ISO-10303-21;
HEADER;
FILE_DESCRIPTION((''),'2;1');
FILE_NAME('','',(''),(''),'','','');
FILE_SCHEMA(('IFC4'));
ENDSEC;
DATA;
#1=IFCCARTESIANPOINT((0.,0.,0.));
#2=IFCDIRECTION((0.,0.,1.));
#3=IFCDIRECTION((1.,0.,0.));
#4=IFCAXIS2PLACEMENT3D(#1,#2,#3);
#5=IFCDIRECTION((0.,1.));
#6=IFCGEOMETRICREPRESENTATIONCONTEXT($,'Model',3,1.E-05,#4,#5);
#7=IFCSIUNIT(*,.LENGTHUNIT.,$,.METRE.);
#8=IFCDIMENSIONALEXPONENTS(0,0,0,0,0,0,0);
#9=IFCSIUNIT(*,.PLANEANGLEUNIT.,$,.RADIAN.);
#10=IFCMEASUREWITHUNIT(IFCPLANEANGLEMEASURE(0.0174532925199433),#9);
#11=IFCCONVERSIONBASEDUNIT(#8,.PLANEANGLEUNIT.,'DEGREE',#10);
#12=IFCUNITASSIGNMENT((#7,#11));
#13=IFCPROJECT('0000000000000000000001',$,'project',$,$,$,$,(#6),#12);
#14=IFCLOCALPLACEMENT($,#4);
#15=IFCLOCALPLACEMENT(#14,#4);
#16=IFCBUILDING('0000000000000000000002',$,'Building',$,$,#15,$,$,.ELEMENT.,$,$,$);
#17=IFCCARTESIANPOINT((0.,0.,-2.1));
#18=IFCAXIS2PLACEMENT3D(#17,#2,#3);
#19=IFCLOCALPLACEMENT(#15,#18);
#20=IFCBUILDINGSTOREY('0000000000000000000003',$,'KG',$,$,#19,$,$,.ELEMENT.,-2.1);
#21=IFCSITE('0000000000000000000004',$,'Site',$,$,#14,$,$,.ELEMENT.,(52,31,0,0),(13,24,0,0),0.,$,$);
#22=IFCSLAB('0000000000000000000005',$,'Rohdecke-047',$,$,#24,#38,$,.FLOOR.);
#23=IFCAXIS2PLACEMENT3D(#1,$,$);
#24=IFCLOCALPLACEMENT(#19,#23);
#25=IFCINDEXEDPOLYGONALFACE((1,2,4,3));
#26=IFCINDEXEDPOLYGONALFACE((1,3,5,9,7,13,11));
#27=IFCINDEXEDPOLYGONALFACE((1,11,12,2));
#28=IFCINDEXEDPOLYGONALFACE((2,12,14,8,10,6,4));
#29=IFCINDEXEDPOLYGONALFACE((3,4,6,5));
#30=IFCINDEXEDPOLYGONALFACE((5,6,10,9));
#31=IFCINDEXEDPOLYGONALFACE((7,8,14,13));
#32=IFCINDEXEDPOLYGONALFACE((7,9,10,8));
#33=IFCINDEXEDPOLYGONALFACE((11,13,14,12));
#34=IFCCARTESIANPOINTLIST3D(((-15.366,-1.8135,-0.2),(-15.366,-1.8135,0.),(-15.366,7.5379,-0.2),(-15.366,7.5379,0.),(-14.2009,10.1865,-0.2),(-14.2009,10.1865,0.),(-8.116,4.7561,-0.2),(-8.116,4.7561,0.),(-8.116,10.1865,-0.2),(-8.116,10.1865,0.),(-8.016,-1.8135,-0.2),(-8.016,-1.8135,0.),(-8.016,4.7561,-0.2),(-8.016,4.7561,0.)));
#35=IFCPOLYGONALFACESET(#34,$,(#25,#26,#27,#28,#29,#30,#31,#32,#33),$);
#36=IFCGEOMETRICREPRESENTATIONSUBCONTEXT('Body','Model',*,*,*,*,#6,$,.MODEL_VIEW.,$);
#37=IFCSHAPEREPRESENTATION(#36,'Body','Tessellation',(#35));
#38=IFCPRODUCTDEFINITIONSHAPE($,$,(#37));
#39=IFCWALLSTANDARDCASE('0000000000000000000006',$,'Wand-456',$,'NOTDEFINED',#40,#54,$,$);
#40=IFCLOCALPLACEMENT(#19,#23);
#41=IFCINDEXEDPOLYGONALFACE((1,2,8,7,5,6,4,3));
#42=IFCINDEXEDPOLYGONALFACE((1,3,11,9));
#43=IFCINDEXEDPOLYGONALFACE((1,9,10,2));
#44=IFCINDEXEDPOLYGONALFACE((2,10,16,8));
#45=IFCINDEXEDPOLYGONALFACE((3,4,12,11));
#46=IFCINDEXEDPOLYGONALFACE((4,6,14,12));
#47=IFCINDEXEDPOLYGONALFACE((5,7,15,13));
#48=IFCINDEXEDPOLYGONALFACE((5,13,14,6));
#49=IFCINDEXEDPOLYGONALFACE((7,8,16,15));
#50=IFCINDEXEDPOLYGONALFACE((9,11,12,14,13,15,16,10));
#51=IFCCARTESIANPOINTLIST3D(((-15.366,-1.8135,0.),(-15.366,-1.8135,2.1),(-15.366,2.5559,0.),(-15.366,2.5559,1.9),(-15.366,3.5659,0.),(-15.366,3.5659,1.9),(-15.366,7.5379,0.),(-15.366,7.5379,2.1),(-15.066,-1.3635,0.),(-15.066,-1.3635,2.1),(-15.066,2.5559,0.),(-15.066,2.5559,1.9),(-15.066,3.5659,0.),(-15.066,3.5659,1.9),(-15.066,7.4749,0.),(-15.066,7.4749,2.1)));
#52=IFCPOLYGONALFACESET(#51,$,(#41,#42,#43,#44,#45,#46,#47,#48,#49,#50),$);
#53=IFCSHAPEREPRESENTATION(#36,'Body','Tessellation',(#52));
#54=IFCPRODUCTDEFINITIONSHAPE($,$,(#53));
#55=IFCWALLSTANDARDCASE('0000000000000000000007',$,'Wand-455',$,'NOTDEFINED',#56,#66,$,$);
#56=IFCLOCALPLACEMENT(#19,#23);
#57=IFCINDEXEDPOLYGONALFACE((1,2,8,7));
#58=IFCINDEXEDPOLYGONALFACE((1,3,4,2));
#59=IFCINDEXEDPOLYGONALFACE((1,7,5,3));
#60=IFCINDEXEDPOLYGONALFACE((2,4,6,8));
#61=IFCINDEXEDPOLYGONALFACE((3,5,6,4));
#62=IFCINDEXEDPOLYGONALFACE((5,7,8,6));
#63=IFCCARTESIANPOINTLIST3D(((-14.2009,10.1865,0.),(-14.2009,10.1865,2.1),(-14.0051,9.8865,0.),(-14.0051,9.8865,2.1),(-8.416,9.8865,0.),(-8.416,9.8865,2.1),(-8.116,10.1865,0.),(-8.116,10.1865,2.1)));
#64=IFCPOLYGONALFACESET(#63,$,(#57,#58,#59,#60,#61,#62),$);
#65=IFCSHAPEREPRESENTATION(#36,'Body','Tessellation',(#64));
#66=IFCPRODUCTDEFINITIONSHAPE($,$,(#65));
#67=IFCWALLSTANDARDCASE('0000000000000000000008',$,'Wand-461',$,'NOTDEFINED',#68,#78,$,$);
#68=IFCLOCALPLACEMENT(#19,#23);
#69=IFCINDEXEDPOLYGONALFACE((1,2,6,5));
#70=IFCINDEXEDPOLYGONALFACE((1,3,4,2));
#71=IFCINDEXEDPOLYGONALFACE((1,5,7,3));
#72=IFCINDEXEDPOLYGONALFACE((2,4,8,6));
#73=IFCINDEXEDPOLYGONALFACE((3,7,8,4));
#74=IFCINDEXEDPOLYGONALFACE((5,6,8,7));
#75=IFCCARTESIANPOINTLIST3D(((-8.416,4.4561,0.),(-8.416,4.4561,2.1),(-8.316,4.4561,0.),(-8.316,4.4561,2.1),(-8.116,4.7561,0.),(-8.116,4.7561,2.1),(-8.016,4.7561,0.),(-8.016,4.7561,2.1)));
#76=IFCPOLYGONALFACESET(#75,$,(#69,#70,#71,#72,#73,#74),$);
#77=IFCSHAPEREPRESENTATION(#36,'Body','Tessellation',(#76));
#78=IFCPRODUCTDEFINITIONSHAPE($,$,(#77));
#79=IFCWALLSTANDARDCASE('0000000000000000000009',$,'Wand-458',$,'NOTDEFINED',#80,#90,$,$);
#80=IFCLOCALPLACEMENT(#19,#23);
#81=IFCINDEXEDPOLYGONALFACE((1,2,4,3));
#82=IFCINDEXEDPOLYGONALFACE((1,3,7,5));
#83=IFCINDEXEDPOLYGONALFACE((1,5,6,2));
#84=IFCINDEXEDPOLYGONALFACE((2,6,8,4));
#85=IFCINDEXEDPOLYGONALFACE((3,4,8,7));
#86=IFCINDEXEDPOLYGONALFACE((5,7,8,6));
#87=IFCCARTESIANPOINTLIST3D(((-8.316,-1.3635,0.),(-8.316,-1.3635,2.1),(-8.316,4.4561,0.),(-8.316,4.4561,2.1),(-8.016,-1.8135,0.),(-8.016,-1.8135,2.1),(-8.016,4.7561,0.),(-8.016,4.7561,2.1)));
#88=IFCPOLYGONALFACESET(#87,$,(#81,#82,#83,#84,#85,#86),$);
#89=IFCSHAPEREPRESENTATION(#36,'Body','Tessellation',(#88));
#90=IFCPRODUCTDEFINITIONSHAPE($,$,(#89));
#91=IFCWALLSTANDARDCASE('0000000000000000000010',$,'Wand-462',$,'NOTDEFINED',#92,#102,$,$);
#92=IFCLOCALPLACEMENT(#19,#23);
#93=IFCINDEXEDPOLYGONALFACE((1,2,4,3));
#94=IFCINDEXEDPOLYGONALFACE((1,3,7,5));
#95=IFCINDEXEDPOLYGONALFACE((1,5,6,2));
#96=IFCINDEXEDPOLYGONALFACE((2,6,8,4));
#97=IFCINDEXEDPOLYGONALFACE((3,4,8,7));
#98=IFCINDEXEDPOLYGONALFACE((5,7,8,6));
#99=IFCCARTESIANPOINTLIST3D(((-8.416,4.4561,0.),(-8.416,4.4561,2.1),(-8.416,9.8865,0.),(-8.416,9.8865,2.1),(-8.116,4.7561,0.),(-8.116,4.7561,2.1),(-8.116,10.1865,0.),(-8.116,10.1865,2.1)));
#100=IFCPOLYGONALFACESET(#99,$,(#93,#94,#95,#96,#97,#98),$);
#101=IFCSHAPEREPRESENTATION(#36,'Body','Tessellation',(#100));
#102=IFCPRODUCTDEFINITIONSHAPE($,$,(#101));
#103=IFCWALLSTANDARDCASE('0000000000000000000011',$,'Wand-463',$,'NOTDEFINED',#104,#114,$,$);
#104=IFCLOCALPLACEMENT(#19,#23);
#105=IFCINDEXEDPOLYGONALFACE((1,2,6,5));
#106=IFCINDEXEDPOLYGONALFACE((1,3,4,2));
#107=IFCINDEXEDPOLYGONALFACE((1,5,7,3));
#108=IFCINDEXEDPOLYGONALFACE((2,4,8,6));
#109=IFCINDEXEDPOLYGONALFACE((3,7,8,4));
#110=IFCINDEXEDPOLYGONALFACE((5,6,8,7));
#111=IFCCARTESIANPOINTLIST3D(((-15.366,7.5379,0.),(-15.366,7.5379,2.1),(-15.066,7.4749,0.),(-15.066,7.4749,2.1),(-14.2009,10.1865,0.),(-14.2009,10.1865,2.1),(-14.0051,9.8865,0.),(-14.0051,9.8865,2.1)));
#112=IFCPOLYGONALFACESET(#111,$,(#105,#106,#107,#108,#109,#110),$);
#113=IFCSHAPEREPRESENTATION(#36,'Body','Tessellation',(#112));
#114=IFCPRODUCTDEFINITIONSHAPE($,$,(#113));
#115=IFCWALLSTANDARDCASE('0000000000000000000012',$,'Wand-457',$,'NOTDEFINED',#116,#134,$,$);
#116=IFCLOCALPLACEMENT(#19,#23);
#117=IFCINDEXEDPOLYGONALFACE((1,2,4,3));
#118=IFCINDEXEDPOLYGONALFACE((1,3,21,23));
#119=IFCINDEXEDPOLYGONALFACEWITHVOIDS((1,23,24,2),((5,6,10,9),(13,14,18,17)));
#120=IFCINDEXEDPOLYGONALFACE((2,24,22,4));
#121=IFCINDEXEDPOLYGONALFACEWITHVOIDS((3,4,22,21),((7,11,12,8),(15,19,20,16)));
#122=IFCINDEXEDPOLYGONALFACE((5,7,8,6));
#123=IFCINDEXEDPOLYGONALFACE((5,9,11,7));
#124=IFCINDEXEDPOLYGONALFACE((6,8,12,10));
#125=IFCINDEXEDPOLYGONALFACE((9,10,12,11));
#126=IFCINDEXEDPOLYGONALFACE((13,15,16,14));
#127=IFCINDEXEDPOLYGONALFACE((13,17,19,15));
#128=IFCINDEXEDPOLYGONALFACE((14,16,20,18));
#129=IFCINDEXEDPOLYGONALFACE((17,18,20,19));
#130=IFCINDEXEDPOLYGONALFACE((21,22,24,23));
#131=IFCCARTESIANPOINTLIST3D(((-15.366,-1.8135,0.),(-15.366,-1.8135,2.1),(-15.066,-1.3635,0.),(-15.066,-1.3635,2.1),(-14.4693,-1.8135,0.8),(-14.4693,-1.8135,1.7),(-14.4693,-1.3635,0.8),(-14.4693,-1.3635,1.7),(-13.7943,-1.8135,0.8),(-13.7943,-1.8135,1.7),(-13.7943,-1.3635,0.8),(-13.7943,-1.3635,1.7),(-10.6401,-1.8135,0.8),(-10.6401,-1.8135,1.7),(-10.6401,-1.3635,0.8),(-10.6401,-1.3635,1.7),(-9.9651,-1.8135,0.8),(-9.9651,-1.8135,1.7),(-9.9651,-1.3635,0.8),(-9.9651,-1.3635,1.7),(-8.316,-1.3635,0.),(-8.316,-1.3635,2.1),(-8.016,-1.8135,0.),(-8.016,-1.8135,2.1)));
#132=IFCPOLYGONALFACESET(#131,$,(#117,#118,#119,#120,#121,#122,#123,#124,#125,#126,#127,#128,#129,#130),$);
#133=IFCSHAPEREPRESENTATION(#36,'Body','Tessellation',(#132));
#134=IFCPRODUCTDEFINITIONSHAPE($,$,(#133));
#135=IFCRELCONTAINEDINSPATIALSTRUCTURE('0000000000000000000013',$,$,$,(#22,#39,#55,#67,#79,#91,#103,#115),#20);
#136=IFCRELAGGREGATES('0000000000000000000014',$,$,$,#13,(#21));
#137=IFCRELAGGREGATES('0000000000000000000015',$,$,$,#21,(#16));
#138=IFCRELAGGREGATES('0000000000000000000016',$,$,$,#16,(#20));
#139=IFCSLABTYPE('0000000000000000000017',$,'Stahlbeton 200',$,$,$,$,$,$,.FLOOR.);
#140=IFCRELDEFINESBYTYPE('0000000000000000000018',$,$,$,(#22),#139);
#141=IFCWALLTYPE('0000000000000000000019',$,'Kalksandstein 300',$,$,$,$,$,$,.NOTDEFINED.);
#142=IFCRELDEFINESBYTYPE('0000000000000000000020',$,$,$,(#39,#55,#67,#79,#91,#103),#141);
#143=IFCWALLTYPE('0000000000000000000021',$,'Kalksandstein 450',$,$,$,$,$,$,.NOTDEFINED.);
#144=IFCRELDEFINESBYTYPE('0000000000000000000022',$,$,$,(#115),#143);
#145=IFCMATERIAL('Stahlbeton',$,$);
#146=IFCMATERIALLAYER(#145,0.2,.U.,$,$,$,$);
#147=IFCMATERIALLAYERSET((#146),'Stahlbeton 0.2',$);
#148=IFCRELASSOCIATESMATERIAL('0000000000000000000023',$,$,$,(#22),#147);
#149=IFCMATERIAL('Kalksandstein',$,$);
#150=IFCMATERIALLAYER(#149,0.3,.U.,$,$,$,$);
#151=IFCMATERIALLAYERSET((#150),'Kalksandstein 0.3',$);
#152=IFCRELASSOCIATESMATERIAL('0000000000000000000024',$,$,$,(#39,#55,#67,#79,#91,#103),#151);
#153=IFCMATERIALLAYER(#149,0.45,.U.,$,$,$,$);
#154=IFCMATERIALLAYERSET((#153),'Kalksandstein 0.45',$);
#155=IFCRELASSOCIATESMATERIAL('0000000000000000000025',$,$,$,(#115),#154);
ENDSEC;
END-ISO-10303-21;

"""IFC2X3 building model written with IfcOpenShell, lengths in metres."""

from ifc_helpers import new_model, entity, si_unit, converted_unit, direction, frame, origin_with_axes, origin_2d_with_axis, place, context, subcontext, project, spatial, polyline, rectangle, outline, extrude, material, layer, layer_set, layer_usage, type_object, element, save


model = new_model("IFC2X3")

# Units and contexts
model_context = context("Model", 3, precision=1e-05, world=origin_with_axes(), true_north=direction((0.0, 1.0)))
body_context = subcontext(model_context, "Body", "Model", "MODEL_VIEW")
ifc_project = project(units=[si_unit("LENGTHUNIT", "METRE"), converted_unit("PLANEANGLEUNIT", "DEGREE", entity("IfcPlaneAngleMeasure", 0.0174532925199433), si_unit("PLANEANGLEUNIT", "RADIAN"), dimensions=[0, 0, 0, 0, 0, 0, 0])], contexts=[model_context])

# Site, building, storey
site_placement = place(None, origin_with_axes())
site = spatial("IfcSite", under=ifc_project, at=site_placement, Name="Site", CompositionType="ELEMENT", RefLatitude=(52, 31, 0, 0), RefLongitude=(13, 24, 0, 0), RefElevation=0.0)
building_placement = place(site_placement, origin_with_axes())
building = spatial("IfcBuilding", under=site, at=building_placement, Name="Building", CompositionType="ELEMENT")
storey_placement = place(building_placement, frame((0.0, 0.0, -2.1), z_axis=(0.0, 0.0, 1.0), x_axis=(1.0, 0.0, 0.0)))
storey = spatial("IfcBuildingStorey", under=building, at=storey_placement, Name="KG", CompositionType="ELEMENT", Elevation=-2.1)

# Slab
ifc_material_1 = material(Name="Stahlbeton")
ifc_layer_1 = layer(ifc_material_1, 0.2, ventilated="UNKNOWN")
ifc_layer_set_1 = layer_set([ifc_layer_1], Name="Stahlbeton 0.2")
ifc_layer_usage_1 = layer_usage(ifc_layer_set_1, "AXIS3", "NEGATIVE", 0.2)
slab_type = type_object("IfcSlabType", Name="Stahlbeton 200", PredefinedType="FLOOR")
slab_placement = place(storey_placement, frame((-14.2009, 10.1865, 0.0), z_axis=(0.0, 0.0, 1.0), x_axis=(1.0, 0.0, 0.0)))
element("IfcSlab", 1, at=slab_placement, inside=storey, type_object=slab_type, material=ifc_layer_usage_1, Name="Rohdecke-047", PredefinedType="FLOOR", context=body_context, shape_type="SweptSolid", body=[
    extrude(outline(polyline([(0.0, 0.0), (-1.1652, -2.6486), (-1.1652, -12.0), (6.1848, -12.0), (6.1848, -5.4304), (6.0848, -5.4304), (6.0848, 0.0), (0.0, 0.0)])), frame((0.0, 0.0, -0.2), z_axis=(0.0, 0.0, 1.0), x_axis=(1.0, 0.0, 0.0)), (0.0, 0.0, 1.0), 0.2),
])

# Wall, opening
ifc_material_2 = material(Name="Kalksandstein")
ifc_layer_2 = layer(ifc_material_2, 0.3, ventilated="UNKNOWN")
ifc_layer_set_2 = layer_set([ifc_layer_2], Name="Kalksandstein 0.3")
ifc_layer_usage_2 = layer_usage(ifc_layer_set_2, "AXIS2", "POSITIVE", 0.0)
wall_type_1 = type_object("IfcWallType", Name="Kalksandstein 300", PredefinedType="NOTDEFINED")
wall_1_placement = place(storey_placement, frame((-15.366, 7.5379, 0.0), z_axis=(0.0, 0.0, 1.0), x_axis=(0.0, -1.0, 0.0)))
wall_1 = element("IfcWallStandardCase", 2, at=wall_1_placement, inside=storey, type_object=wall_type_1, material=ifc_layer_usage_2, Name="Wand-456", ObjectType="NOTDEFINED", context=body_context, shape_type="SweptSolid", body=[
    extrude(outline(polyline([(0.0, 0.0), (9.3514, 0.0), (8.9014, 0.3), (0.0631, 0.3), (0.0, 0.0)])), origin_with_axes(), (0.0, 0.0, 1.0), 2.1),
])
opening_1_placement = place(wall_1_placement, frame((4.4771, 0.0, 0.0), z_axis=(0.0, 0.0, 1.0), x_axis=(1.0, 0.0, 0.0)))
element("IfcOpeningElement", 3, at=opening_1_placement, cuts=wall_1, context=body_context, shape_type="SweptSolid", body=[
    extrude(rectangle(XDim=1.01, YDim=1.9, at=origin_2d_with_axis()), frame((0.0, 0.3, 0.95), z_axis=(0.0, 1.0, 0.0), x_axis=(-1.0, 0.0, 0.0)), (0.0, 0.0, -1.0), 0.9),
])

# Walls
ifc_layer_usage_3 = layer_usage(ifc_layer_set_2, "AXIS2", "POSITIVE", 0.0)
wall_2_placement = place(storey_placement, frame((-8.116, 10.1865, 0.0), z_axis=(0.0, 0.0, 1.0), x_axis=(-1.0, 0.0, 0.0)))
element("IfcWallStandardCase", 4, at=wall_2_placement, inside=storey, type_object=wall_type_1, material=ifc_layer_usage_3, Name="Wand-455", ObjectType="NOTDEFINED", context=body_context, shape_type="SweptSolid", body=[
    extrude(outline(polyline([(0.0, 0.0), (6.0848, 0.0), (5.8891, 0.3), (0.3, 0.3), (0.0, 0.0)])), origin_with_axes(), (0.0, 0.0, 1.0), 2.1),
])
ifc_layer_usage_4 = layer_usage(ifc_layer_set_2, "AXIS2", "POSITIVE", 0.0)
wall_3_placement = place(storey_placement, frame((-8.016, 4.7561, 0.0), z_axis=(0.0, 0.0, 1.0), x_axis=(-1.0, 0.0, 0.0)))
element("IfcWallStandardCase", 5, at=wall_3_placement, inside=storey, type_object=wall_type_1, material=ifc_layer_usage_4, Name="Wand-461", ObjectType="NOTDEFINED", context=body_context, shape_type="SweptSolid", body=[
    extrude(outline(polyline([(0.0, 0.0), (0.1, 0.0), (0.4, 0.3), (0.3, 0.3), (0.0, 0.0)])), origin_with_axes(), (0.0, 0.0, 1.0), 2.1),
])
ifc_layer_usage_5 = layer_usage(ifc_layer_set_2, "AXIS2", "POSITIVE", 0.0)
wall_4_placement = place(storey_placement, frame((-8.016, -1.8135, 0.0), z_axis=(0.0, 0.0, 1.0), x_axis=(0.0, 1.0, 0.0)))
element("IfcWallStandardCase", 6, at=wall_4_placement, inside=storey, type_object=wall_type_1, material=ifc_layer_usage_5, Name="Wand-458", ObjectType="NOTDEFINED", context=body_context, shape_type="SweptSolid", body=[
    extrude(outline(polyline([(0.0, 0.0), (6.5696, 0.0), (6.2696, 0.3), (0.45, 0.3), (0.0, 0.0)])), origin_with_axes(), (0.0, 0.0, 1.0), 2.1),
])
ifc_layer_usage_6 = layer_usage(ifc_layer_set_2, "AXIS2", "POSITIVE", 0.0)
wall_5_placement = place(storey_placement, frame((-8.116, 4.7561, 0.0), z_axis=(0.0, 0.0, 1.0), x_axis=(0.0, 1.0, 0.0)))
element("IfcWallStandardCase", 7, at=wall_5_placement, inside=storey, type_object=wall_type_1, material=ifc_layer_usage_6, Name="Wand-462", ObjectType="NOTDEFINED", context=body_context, shape_type="SweptSolid", body=[
    extrude(outline(polyline([(0.0, 0.0), (5.4304, 0.0), (5.1304, 0.3), (-0.3, 0.3), (0.0, 0.0)])), origin_with_axes(), (0.0, 0.0, 1.0), 2.1),
])
ifc_layer_usage_7 = layer_usage(ifc_layer_set_2, "AXIS2", "POSITIVE", 0.0)
wall_6_placement = place(storey_placement, frame((-14.2009, 10.1865, 0.0), z_axis=(0.0, 0.0, 1.0), x_axis=(-0.402674, -0.915343, 0.0)))
element("IfcWallStandardCase", 8, at=wall_6_placement, inside=storey, type_object=wall_type_1, material=ifc_layer_usage_7, Name="Wand-463", ObjectType="NOTDEFINED", context=body_context, shape_type="SweptSolid", body=[
    extrude(outline(polyline([(0.0, 0.0), (2.8935, 0.0), (2.8305, 0.3), (0.1958, 0.3), (0.0, 0.0)])), origin_with_axes(), (0.0, 0.0, 1.0), 2.1),
])

# Wall, openings
ifc_layer_3 = layer(ifc_material_2, 0.45, ventilated="UNKNOWN")
ifc_layer_set_3 = layer_set([ifc_layer_3], Name="Kalksandstein 0.45")
ifc_layer_usage_8 = layer_usage(ifc_layer_set_3, "AXIS2", "POSITIVE", 0.0)
wall_type_2 = type_object("IfcWallType", Name="Kalksandstein 450", PredefinedType="NOTDEFINED")
wall_7_placement = place(storey_placement, frame((-15.366, -1.8135, 0.0), z_axis=(0.0, 0.0, 1.0), x_axis=(1.0, 0.0, 0.0)))
wall_7 = element("IfcWallStandardCase", 9, at=wall_7_placement, inside=storey, type_object=wall_type_2, material=ifc_layer_usage_8, Name="Wand-457", ObjectType="NOTDEFINED", context=body_context, shape_type="SweptSolid", body=[
    extrude(outline(polyline([(0.0, 0.0), (7.35, 0.0), (7.05, 0.45), (0.3, 0.45), (0.0, 0.0)])), origin_with_axes(), (0.0, 0.0, 1.0), 2.1),
])
opening_2_placement = place(wall_7_placement, frame((5.0634, 0.0, 0.8), z_axis=(0.0, 0.0, 1.0), x_axis=(1.0, 0.0, 0.0)))
element("IfcOpeningElement", 10, at=opening_2_placement, cuts=wall_7, context=body_context, shape_type="SweptSolid", body=[
    extrude(rectangle(XDim=0.675, YDim=0.9, at=origin_2d_with_axis()), frame((0.0, 0.45, 0.45), z_axis=(0.0, 1.0, 0.0), x_axis=(1.0, 0.0, 0.0)), (0.0, 0.0, -1.0), 1.35),
])
opening_3_placement = place(wall_7_placement, frame((1.2343, 0.0, 0.8), z_axis=(0.0, 0.0, 1.0), x_axis=(1.0, 0.0, 0.0)))
element("IfcOpeningElement", 11, at=opening_3_placement, cuts=wall_7, context=body_context, shape_type="SweptSolid", body=[
    extrude(rectangle(XDim=0.675, YDim=0.9, at=origin_2d_with_axis()), frame((0.0, 0.45, 0.45), z_axis=(0.0, 1.0, 0.0), x_axis=(1.0, 0.0, 0.0)), (0.0, 0.0, -1.0), 1.35),
])

save(model, "model.ifc")
